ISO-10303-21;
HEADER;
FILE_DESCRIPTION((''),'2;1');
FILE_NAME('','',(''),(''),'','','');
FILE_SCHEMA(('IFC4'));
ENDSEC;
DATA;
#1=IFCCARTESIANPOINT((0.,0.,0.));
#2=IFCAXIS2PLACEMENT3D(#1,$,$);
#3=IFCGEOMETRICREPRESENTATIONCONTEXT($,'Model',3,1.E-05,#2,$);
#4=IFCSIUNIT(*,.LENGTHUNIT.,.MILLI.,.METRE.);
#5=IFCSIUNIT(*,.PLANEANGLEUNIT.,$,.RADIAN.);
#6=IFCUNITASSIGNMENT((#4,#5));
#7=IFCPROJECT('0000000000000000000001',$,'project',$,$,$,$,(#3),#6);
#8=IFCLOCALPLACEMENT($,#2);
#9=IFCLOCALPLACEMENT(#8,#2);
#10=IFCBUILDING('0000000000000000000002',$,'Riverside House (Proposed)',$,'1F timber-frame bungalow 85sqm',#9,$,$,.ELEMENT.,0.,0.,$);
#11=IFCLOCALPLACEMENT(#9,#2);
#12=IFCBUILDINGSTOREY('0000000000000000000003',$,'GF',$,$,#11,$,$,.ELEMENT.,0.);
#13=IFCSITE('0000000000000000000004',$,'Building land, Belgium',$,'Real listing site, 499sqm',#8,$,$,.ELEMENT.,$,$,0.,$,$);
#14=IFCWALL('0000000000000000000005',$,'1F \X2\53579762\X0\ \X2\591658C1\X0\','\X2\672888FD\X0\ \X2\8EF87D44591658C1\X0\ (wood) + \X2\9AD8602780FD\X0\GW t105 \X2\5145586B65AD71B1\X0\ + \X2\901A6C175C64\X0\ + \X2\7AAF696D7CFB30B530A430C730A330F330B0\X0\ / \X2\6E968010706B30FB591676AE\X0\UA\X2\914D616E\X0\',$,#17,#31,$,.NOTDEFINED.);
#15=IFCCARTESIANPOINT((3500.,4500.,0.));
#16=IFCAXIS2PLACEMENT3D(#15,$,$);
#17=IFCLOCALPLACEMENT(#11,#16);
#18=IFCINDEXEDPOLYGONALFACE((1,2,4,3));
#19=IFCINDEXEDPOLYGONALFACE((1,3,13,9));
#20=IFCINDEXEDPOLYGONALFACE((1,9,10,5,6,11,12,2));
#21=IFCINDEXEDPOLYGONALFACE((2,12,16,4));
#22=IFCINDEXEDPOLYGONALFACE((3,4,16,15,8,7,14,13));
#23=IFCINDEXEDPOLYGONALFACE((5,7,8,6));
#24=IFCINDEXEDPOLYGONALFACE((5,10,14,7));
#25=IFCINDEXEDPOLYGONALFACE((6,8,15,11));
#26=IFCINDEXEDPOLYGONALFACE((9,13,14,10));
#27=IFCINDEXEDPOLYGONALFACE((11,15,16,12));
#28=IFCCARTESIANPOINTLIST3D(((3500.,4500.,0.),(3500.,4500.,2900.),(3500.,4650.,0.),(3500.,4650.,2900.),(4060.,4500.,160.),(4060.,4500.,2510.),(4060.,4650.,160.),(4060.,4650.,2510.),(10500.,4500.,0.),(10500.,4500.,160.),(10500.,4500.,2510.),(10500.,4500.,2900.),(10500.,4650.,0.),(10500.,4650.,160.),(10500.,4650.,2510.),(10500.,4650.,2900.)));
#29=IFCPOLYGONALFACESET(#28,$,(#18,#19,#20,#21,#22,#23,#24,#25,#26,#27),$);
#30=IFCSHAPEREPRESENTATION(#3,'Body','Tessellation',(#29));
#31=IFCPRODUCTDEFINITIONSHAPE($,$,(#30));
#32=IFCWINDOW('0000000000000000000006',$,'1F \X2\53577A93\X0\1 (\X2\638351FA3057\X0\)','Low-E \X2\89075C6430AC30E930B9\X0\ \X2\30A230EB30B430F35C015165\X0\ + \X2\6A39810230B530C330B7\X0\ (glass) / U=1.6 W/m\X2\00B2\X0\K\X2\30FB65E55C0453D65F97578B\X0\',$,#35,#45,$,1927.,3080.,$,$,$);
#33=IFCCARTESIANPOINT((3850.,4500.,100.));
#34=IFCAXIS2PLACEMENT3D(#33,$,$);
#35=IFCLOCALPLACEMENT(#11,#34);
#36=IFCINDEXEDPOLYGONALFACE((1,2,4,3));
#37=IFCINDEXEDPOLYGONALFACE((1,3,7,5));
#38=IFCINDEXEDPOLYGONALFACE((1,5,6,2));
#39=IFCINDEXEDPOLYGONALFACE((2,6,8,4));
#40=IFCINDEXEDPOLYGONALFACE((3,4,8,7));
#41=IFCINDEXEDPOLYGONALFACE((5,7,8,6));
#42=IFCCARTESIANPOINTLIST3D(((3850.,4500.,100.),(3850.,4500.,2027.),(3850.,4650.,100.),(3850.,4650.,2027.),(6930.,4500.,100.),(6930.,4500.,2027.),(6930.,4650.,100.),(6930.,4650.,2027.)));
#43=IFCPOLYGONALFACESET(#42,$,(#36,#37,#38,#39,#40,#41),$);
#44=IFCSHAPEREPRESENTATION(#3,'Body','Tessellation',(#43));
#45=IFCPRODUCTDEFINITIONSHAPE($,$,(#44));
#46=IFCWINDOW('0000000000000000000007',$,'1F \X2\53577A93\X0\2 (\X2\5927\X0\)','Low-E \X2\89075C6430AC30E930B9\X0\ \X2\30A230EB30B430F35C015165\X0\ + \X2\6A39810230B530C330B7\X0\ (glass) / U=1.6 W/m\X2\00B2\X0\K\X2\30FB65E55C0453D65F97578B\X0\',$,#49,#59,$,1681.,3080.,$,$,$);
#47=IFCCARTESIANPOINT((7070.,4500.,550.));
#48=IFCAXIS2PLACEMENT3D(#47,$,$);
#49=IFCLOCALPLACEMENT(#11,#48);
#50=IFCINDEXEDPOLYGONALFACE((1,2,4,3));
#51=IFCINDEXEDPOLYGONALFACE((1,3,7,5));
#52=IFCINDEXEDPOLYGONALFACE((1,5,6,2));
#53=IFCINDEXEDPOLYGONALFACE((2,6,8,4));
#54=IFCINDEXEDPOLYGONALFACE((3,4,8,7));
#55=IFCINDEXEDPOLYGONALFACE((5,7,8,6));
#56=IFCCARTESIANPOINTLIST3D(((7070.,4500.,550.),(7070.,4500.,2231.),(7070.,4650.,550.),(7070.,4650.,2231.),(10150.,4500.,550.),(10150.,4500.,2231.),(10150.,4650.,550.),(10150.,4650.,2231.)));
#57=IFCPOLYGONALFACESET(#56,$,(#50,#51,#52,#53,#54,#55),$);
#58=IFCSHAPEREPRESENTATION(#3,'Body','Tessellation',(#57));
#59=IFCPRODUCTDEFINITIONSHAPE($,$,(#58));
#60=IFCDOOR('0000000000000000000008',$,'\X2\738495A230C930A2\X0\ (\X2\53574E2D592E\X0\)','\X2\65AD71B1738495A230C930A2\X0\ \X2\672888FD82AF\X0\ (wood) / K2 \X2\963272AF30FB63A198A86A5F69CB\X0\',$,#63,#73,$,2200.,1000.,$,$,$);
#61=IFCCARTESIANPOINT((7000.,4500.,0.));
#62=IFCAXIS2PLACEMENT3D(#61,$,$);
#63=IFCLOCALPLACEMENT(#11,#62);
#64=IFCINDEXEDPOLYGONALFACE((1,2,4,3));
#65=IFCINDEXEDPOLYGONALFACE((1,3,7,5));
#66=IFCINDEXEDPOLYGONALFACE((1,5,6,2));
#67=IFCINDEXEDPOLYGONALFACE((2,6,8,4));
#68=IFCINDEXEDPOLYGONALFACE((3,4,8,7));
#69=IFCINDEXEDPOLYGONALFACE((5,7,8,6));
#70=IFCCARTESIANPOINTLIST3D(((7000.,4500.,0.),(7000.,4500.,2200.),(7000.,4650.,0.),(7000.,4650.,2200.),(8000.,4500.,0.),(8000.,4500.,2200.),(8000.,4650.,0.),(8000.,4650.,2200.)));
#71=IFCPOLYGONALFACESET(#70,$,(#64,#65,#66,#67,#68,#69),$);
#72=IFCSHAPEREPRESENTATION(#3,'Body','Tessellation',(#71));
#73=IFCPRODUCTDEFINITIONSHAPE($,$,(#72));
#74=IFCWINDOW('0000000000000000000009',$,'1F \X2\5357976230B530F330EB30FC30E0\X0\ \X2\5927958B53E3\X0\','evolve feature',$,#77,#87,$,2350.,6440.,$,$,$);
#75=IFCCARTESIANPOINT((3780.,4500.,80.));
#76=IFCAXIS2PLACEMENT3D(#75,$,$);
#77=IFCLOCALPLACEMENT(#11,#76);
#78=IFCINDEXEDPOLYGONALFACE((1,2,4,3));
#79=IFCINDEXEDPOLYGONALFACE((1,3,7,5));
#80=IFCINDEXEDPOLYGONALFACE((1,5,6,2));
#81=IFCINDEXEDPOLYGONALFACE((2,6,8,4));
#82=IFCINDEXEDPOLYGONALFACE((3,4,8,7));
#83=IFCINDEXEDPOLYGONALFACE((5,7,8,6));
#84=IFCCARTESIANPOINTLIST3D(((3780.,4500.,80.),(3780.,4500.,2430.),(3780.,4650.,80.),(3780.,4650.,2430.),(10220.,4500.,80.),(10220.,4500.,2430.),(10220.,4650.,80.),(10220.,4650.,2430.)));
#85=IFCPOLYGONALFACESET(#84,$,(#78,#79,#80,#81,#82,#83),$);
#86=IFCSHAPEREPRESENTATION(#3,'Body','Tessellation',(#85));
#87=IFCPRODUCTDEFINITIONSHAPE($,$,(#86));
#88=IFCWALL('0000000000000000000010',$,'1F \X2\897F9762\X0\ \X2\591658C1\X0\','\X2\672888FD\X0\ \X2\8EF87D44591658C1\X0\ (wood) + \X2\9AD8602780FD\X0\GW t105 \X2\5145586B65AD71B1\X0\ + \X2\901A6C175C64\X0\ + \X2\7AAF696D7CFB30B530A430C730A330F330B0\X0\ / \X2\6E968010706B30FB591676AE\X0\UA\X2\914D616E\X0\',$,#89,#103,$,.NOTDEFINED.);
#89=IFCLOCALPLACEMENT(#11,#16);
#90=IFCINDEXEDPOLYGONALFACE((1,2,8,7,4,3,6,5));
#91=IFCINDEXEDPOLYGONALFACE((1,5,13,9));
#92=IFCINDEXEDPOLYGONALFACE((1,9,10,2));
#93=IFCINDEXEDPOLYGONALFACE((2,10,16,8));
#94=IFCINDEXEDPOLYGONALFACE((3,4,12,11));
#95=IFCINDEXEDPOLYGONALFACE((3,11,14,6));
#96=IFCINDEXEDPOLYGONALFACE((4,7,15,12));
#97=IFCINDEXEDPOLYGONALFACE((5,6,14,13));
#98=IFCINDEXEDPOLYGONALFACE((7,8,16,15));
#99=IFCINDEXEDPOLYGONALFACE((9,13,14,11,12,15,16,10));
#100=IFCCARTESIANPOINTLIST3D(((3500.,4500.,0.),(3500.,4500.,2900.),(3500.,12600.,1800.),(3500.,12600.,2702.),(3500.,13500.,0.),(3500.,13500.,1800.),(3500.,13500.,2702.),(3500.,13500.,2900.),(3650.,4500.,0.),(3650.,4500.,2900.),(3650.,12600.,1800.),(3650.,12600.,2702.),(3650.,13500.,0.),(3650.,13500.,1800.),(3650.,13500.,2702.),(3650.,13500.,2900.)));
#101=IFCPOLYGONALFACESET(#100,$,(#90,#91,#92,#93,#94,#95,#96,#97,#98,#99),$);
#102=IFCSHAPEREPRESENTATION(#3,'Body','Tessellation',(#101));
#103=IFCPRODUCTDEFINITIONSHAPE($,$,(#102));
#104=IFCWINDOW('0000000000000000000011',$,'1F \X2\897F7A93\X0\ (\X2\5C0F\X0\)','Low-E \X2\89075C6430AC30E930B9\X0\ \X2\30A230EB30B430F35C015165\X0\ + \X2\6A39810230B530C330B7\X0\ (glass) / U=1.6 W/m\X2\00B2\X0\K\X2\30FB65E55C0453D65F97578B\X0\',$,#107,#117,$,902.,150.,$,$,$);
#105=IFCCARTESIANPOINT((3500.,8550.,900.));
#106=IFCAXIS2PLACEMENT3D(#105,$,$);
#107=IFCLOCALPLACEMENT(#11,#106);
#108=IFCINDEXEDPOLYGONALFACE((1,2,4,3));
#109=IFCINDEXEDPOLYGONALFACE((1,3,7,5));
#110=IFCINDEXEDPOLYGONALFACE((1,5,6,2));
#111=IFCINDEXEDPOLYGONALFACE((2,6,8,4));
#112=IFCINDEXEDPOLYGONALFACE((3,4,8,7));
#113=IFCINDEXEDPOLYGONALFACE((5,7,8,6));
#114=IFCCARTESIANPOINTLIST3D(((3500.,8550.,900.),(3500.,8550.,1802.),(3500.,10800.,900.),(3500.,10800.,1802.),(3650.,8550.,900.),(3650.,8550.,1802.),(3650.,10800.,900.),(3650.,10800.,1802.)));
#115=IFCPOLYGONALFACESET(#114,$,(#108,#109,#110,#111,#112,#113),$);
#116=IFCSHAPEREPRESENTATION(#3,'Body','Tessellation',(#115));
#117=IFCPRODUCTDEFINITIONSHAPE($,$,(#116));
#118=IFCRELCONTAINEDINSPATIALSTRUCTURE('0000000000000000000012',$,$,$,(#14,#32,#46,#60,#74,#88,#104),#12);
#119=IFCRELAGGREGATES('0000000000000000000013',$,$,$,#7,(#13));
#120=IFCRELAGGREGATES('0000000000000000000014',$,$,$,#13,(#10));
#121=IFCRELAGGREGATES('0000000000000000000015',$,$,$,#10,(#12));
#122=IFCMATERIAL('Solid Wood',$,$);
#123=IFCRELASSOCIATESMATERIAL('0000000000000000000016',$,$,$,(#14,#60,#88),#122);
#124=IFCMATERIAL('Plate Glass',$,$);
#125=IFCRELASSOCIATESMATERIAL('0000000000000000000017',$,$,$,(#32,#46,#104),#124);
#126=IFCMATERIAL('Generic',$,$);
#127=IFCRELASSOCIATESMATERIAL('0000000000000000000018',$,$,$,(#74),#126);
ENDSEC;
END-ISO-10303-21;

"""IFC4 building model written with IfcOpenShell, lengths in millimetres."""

from ifc_helpers import new_model, si_unit, frame, frame_2d, origin, place, context, project, spatial, rectangle, extrude, material, element, fill, save


model = new_model("IFC4")

# Units and contexts
model_context = context("Model", 3, precision=1e-05, world=origin())
ifc_project = project(units=[si_unit("LENGTHUNIT", "METRE", prefix="MILLI"), si_unit("PLANEANGLEUNIT", "RADIAN")], contexts=[model_context])

# Site, building, storey
site_placement = place(None, origin())
site = spatial("IfcSite", under=ifc_project, at=site_placement, Name="Building land, Belgium", ObjectType="Real listing site, 499sqm", CompositionType="ELEMENT", RefElevation=0.0)
building_placement = place(site_placement, origin())
building = spatial("IfcBuilding", under=site, at=building_placement, Name="Riverside House (Proposed)", ObjectType="1F timber-frame bungalow 85sqm", CompositionType="ELEMENT", ElevationOfRefHeight=0.0, ElevationOfTerrain=0.0)
storey_placement = place(building_placement, origin())
storey = spatial("IfcBuildingStorey", under=building, at=storey_placement, Name="GF", CompositionType="ELEMENT", Elevation=0.0)

# Shared definitions
ifc_material_1 = material(Name="Solid Wood")
ifc_material_2 = material(Name="Generic")

# Wall, openings, windows, door
wall_1_placement = place(storey_placement, frame((3500.0, 4500.0, 0.0)))
wall_1 = element("IfcWall", 1, at=wall_1_placement, inside=storey, material=ifc_material_1, Name="1F 南面 外壁", Description="木製 軸組外壁 (wood) + 高性能GW t105 充填断熱 + 通気層 + 窯業系サイディング / 準耐火・外皮UA配慮", PredefinedType="NOTDEFINED", context=model_context, shape_type="SweptSolid", body=[
    extrude(rectangle(XDim=7000.0, YDim=150.0, at=frame_2d((3500.0, 75.0))), frame((3500.0, 4500.0, 0.0)), (0.0, 0.0, 1.0), 2900.0),
])
opening_1_placement = place(storey_placement, frame((3850.0, 4500.0, 100.0)))
opening_1 = element("IfcOpeningElement", 2, at=opening_1_placement, cuts=wall_1, PredefinedType="NOTDEFINED", context=model_context, shape_type="SweptSolid", body=[
    extrude(rectangle(XDim=3080.0, YDim=150.0, at=frame_2d((1540.0, 75.0))), frame((3850.0, 4500.0, 100.0)), (0.0, 0.0, 1.0), 1927.0),
])
opening_2_placement = place(storey_placement, frame((7070.0, 4500.0, 550.0)))
opening_2 = element("IfcOpeningElement", 3, at=opening_2_placement, cuts=wall_1, PredefinedType="NOTDEFINED", context=model_context, shape_type="SweptSolid", body=[
    extrude(rectangle(XDim=3080.0, YDim=150.0, at=frame_2d((1540.0, 75.0))), frame((7070.0, 4500.0, 550.0)), (0.0, 0.0, 1.0), 1681.0),
])
opening_3_placement = place(storey_placement, frame((7000.0, 4500.0, 0.0)))
opening_3 = element("IfcOpeningElement", 4, at=opening_3_placement, cuts=wall_1, PredefinedType="NOTDEFINED", context=model_context, shape_type="SweptSolid", body=[
    extrude(rectangle(XDim=1000.0, YDim=150.0, at=frame_2d((500.0, 75.0))), frame((7000.0, 4500.0, 0.0)), (0.0, 0.0, 1.0), 2200.0),
])
opening_4_placement = place(storey_placement, frame((3780.0, 4500.0, 80.0)))
opening_4 = element("IfcOpeningElement", 5, at=opening_4_placement, cuts=wall_1, PredefinedType="NOTDEFINED", context=model_context, shape_type="SweptSolid", body=[
    extrude(rectangle(XDim=6440.0, YDim=150.0, at=frame_2d((3220.0, 75.0))), frame((3780.0, 4500.0, 80.0)), (0.0, 0.0, 1.0), 2350.0),
])
ifc_material_3 = material(Name="Plate Glass")
window_1_placement = place(storey_placement, frame((3850.0, 4500.0, 100.0)))
window_1 = element("IfcWindow", 6, at=window_1_placement, inside=storey, material=ifc_material_3, Name="1F 南窓1 (掃出し)", Description="Low-E 複層ガラス アルゴン封入 + 樹脂サッシ (glass) / U=1.6 W/m²K・日射取得型", OverallHeight=1927.0, OverallWidth=3080.0, context=model_context, shape_type="SweptSolid", body=[
    extrude(rectangle(XDim=3080.0, YDim=150.0, at=frame_2d((1540.0, 75.0))), frame((3850.0, 4500.0, 100.0)), (0.0, 0.0, 1.0), 1927.0),
])
fill(opening_1, window_1)
window_2_placement = place(storey_placement, frame((7070.0, 4500.0, 550.0)))
window_2 = element("IfcWindow", 7, at=window_2_placement, inside=storey, material=ifc_material_3, Name="1F 南窓2 (大)", Description="Low-E 複層ガラス アルゴン封入 + 樹脂サッシ (glass) / U=1.6 W/m²K・日射取得型", OverallHeight=1681.0, OverallWidth=3080.0, context=model_context, shape_type="SweptSolid", body=[
    extrude(rectangle(XDim=3080.0, YDim=150.0, at=frame_2d((1540.0, 75.0))), frame((7070.0, 4500.0, 550.0)), (0.0, 0.0, 1.0), 1681.0),
])
fill(opening_2, window_2)
door_placement = place(storey_placement, frame((7000.0, 4500.0, 0.0)))
door = element("IfcDoor", 8, at=door_placement, inside=storey, material=ifc_material_1, Name="玄関ドア (南中央)", Description="断熱玄関ドア 木製芯 (wood) / K2 防犯・採風機構", OverallHeight=2200.0, OverallWidth=1000.0, context=model_context, shape_type="SweptSolid", body=[
    extrude(rectangle(XDim=1000.0, YDim=150.0, at=frame_2d((500.0, 75.0))), frame((7000.0, 4500.0, 0.0)), (0.0, 0.0, 1.0), 2200.0),
])
fill(opening_3, door)
window_3_placement = place(storey_placement, frame((3780.0, 4500.0, 80.0)))
window_3 = element("IfcWindow", 9, at=window_3_placement, inside=storey, material=ifc_material_2, Name="1F 南面サンルーム 大開口", Description="evolve feature", OverallHeight=2350.0, OverallWidth=6440.0, context=model_context, shape_type="SweptSolid", body=[
    extrude(rectangle(XDim=6440.0, YDim=150.0, at=frame_2d((3220.0, 75.0))), frame((3780.0, 4500.0, 80.0)), (0.0, 0.0, 1.0), 2350.0),
])
fill(opening_4, window_3)

# Wall, opening, window
wall_2_placement = place(storey_placement, frame((3500.0, 4500.0, 0.0)))
wall_2 = element("IfcWall", 10, at=wall_2_placement, inside=storey, material=ifc_material_1, Name="1F 西面 外壁", Description="木製 軸組外壁 (wood) + 高性能GW t105 充填断熱 + 通気層 + 窯業系サイディング / 準耐火・外皮UA配慮", PredefinedType="NOTDEFINED", context=model_context, shape_type="SweptSolid", body=[
    extrude(rectangle(XDim=150.0, YDim=9000.0, at=frame_2d((75.0, 4500.0))), frame((3500.0, 4500.0, 0.0)), (0.0, 0.0, 1.0), 2900.0),
])
opening_5_placement = place(storey_placement, frame((3500.0, 8550.0, 900.0)))
opening_5 = element("IfcOpeningElement", 11, at=opening_5_placement, cuts=wall_2, PredefinedType="NOTDEFINED", context=model_context, shape_type="SweptSolid", body=[
    extrude(rectangle(XDim=150.0, YDim=2250.0, at=frame_2d((75.0, 1125.0))), frame((3500.0, 8550.0, 900.0)), (0.0, 0.0, 1.0), 902.0),
])
window_4_placement = place(storey_placement, frame((3500.0, 8550.0, 900.0)))
window_4 = element("IfcWindow", 12, at=window_4_placement, inside=storey, material=ifc_material_3, Name="1F 西窓 (小)", Description="Low-E 複層ガラス アルゴン封入 + 樹脂サッシ (glass) / U=1.6 W/m²K・日射取得型", OverallHeight=902.0, OverallWidth=150.0, context=model_context, shape_type="SweptSolid", body=[
    extrude(rectangle(XDim=150.0, YDim=2250.0, at=frame_2d((75.0, 1125.0))), frame((3500.0, 8550.0, 900.0)), (0.0, 0.0, 1.0), 902.0),
])
fill(opening_5, window_4)

save(model, "model.ifc")
